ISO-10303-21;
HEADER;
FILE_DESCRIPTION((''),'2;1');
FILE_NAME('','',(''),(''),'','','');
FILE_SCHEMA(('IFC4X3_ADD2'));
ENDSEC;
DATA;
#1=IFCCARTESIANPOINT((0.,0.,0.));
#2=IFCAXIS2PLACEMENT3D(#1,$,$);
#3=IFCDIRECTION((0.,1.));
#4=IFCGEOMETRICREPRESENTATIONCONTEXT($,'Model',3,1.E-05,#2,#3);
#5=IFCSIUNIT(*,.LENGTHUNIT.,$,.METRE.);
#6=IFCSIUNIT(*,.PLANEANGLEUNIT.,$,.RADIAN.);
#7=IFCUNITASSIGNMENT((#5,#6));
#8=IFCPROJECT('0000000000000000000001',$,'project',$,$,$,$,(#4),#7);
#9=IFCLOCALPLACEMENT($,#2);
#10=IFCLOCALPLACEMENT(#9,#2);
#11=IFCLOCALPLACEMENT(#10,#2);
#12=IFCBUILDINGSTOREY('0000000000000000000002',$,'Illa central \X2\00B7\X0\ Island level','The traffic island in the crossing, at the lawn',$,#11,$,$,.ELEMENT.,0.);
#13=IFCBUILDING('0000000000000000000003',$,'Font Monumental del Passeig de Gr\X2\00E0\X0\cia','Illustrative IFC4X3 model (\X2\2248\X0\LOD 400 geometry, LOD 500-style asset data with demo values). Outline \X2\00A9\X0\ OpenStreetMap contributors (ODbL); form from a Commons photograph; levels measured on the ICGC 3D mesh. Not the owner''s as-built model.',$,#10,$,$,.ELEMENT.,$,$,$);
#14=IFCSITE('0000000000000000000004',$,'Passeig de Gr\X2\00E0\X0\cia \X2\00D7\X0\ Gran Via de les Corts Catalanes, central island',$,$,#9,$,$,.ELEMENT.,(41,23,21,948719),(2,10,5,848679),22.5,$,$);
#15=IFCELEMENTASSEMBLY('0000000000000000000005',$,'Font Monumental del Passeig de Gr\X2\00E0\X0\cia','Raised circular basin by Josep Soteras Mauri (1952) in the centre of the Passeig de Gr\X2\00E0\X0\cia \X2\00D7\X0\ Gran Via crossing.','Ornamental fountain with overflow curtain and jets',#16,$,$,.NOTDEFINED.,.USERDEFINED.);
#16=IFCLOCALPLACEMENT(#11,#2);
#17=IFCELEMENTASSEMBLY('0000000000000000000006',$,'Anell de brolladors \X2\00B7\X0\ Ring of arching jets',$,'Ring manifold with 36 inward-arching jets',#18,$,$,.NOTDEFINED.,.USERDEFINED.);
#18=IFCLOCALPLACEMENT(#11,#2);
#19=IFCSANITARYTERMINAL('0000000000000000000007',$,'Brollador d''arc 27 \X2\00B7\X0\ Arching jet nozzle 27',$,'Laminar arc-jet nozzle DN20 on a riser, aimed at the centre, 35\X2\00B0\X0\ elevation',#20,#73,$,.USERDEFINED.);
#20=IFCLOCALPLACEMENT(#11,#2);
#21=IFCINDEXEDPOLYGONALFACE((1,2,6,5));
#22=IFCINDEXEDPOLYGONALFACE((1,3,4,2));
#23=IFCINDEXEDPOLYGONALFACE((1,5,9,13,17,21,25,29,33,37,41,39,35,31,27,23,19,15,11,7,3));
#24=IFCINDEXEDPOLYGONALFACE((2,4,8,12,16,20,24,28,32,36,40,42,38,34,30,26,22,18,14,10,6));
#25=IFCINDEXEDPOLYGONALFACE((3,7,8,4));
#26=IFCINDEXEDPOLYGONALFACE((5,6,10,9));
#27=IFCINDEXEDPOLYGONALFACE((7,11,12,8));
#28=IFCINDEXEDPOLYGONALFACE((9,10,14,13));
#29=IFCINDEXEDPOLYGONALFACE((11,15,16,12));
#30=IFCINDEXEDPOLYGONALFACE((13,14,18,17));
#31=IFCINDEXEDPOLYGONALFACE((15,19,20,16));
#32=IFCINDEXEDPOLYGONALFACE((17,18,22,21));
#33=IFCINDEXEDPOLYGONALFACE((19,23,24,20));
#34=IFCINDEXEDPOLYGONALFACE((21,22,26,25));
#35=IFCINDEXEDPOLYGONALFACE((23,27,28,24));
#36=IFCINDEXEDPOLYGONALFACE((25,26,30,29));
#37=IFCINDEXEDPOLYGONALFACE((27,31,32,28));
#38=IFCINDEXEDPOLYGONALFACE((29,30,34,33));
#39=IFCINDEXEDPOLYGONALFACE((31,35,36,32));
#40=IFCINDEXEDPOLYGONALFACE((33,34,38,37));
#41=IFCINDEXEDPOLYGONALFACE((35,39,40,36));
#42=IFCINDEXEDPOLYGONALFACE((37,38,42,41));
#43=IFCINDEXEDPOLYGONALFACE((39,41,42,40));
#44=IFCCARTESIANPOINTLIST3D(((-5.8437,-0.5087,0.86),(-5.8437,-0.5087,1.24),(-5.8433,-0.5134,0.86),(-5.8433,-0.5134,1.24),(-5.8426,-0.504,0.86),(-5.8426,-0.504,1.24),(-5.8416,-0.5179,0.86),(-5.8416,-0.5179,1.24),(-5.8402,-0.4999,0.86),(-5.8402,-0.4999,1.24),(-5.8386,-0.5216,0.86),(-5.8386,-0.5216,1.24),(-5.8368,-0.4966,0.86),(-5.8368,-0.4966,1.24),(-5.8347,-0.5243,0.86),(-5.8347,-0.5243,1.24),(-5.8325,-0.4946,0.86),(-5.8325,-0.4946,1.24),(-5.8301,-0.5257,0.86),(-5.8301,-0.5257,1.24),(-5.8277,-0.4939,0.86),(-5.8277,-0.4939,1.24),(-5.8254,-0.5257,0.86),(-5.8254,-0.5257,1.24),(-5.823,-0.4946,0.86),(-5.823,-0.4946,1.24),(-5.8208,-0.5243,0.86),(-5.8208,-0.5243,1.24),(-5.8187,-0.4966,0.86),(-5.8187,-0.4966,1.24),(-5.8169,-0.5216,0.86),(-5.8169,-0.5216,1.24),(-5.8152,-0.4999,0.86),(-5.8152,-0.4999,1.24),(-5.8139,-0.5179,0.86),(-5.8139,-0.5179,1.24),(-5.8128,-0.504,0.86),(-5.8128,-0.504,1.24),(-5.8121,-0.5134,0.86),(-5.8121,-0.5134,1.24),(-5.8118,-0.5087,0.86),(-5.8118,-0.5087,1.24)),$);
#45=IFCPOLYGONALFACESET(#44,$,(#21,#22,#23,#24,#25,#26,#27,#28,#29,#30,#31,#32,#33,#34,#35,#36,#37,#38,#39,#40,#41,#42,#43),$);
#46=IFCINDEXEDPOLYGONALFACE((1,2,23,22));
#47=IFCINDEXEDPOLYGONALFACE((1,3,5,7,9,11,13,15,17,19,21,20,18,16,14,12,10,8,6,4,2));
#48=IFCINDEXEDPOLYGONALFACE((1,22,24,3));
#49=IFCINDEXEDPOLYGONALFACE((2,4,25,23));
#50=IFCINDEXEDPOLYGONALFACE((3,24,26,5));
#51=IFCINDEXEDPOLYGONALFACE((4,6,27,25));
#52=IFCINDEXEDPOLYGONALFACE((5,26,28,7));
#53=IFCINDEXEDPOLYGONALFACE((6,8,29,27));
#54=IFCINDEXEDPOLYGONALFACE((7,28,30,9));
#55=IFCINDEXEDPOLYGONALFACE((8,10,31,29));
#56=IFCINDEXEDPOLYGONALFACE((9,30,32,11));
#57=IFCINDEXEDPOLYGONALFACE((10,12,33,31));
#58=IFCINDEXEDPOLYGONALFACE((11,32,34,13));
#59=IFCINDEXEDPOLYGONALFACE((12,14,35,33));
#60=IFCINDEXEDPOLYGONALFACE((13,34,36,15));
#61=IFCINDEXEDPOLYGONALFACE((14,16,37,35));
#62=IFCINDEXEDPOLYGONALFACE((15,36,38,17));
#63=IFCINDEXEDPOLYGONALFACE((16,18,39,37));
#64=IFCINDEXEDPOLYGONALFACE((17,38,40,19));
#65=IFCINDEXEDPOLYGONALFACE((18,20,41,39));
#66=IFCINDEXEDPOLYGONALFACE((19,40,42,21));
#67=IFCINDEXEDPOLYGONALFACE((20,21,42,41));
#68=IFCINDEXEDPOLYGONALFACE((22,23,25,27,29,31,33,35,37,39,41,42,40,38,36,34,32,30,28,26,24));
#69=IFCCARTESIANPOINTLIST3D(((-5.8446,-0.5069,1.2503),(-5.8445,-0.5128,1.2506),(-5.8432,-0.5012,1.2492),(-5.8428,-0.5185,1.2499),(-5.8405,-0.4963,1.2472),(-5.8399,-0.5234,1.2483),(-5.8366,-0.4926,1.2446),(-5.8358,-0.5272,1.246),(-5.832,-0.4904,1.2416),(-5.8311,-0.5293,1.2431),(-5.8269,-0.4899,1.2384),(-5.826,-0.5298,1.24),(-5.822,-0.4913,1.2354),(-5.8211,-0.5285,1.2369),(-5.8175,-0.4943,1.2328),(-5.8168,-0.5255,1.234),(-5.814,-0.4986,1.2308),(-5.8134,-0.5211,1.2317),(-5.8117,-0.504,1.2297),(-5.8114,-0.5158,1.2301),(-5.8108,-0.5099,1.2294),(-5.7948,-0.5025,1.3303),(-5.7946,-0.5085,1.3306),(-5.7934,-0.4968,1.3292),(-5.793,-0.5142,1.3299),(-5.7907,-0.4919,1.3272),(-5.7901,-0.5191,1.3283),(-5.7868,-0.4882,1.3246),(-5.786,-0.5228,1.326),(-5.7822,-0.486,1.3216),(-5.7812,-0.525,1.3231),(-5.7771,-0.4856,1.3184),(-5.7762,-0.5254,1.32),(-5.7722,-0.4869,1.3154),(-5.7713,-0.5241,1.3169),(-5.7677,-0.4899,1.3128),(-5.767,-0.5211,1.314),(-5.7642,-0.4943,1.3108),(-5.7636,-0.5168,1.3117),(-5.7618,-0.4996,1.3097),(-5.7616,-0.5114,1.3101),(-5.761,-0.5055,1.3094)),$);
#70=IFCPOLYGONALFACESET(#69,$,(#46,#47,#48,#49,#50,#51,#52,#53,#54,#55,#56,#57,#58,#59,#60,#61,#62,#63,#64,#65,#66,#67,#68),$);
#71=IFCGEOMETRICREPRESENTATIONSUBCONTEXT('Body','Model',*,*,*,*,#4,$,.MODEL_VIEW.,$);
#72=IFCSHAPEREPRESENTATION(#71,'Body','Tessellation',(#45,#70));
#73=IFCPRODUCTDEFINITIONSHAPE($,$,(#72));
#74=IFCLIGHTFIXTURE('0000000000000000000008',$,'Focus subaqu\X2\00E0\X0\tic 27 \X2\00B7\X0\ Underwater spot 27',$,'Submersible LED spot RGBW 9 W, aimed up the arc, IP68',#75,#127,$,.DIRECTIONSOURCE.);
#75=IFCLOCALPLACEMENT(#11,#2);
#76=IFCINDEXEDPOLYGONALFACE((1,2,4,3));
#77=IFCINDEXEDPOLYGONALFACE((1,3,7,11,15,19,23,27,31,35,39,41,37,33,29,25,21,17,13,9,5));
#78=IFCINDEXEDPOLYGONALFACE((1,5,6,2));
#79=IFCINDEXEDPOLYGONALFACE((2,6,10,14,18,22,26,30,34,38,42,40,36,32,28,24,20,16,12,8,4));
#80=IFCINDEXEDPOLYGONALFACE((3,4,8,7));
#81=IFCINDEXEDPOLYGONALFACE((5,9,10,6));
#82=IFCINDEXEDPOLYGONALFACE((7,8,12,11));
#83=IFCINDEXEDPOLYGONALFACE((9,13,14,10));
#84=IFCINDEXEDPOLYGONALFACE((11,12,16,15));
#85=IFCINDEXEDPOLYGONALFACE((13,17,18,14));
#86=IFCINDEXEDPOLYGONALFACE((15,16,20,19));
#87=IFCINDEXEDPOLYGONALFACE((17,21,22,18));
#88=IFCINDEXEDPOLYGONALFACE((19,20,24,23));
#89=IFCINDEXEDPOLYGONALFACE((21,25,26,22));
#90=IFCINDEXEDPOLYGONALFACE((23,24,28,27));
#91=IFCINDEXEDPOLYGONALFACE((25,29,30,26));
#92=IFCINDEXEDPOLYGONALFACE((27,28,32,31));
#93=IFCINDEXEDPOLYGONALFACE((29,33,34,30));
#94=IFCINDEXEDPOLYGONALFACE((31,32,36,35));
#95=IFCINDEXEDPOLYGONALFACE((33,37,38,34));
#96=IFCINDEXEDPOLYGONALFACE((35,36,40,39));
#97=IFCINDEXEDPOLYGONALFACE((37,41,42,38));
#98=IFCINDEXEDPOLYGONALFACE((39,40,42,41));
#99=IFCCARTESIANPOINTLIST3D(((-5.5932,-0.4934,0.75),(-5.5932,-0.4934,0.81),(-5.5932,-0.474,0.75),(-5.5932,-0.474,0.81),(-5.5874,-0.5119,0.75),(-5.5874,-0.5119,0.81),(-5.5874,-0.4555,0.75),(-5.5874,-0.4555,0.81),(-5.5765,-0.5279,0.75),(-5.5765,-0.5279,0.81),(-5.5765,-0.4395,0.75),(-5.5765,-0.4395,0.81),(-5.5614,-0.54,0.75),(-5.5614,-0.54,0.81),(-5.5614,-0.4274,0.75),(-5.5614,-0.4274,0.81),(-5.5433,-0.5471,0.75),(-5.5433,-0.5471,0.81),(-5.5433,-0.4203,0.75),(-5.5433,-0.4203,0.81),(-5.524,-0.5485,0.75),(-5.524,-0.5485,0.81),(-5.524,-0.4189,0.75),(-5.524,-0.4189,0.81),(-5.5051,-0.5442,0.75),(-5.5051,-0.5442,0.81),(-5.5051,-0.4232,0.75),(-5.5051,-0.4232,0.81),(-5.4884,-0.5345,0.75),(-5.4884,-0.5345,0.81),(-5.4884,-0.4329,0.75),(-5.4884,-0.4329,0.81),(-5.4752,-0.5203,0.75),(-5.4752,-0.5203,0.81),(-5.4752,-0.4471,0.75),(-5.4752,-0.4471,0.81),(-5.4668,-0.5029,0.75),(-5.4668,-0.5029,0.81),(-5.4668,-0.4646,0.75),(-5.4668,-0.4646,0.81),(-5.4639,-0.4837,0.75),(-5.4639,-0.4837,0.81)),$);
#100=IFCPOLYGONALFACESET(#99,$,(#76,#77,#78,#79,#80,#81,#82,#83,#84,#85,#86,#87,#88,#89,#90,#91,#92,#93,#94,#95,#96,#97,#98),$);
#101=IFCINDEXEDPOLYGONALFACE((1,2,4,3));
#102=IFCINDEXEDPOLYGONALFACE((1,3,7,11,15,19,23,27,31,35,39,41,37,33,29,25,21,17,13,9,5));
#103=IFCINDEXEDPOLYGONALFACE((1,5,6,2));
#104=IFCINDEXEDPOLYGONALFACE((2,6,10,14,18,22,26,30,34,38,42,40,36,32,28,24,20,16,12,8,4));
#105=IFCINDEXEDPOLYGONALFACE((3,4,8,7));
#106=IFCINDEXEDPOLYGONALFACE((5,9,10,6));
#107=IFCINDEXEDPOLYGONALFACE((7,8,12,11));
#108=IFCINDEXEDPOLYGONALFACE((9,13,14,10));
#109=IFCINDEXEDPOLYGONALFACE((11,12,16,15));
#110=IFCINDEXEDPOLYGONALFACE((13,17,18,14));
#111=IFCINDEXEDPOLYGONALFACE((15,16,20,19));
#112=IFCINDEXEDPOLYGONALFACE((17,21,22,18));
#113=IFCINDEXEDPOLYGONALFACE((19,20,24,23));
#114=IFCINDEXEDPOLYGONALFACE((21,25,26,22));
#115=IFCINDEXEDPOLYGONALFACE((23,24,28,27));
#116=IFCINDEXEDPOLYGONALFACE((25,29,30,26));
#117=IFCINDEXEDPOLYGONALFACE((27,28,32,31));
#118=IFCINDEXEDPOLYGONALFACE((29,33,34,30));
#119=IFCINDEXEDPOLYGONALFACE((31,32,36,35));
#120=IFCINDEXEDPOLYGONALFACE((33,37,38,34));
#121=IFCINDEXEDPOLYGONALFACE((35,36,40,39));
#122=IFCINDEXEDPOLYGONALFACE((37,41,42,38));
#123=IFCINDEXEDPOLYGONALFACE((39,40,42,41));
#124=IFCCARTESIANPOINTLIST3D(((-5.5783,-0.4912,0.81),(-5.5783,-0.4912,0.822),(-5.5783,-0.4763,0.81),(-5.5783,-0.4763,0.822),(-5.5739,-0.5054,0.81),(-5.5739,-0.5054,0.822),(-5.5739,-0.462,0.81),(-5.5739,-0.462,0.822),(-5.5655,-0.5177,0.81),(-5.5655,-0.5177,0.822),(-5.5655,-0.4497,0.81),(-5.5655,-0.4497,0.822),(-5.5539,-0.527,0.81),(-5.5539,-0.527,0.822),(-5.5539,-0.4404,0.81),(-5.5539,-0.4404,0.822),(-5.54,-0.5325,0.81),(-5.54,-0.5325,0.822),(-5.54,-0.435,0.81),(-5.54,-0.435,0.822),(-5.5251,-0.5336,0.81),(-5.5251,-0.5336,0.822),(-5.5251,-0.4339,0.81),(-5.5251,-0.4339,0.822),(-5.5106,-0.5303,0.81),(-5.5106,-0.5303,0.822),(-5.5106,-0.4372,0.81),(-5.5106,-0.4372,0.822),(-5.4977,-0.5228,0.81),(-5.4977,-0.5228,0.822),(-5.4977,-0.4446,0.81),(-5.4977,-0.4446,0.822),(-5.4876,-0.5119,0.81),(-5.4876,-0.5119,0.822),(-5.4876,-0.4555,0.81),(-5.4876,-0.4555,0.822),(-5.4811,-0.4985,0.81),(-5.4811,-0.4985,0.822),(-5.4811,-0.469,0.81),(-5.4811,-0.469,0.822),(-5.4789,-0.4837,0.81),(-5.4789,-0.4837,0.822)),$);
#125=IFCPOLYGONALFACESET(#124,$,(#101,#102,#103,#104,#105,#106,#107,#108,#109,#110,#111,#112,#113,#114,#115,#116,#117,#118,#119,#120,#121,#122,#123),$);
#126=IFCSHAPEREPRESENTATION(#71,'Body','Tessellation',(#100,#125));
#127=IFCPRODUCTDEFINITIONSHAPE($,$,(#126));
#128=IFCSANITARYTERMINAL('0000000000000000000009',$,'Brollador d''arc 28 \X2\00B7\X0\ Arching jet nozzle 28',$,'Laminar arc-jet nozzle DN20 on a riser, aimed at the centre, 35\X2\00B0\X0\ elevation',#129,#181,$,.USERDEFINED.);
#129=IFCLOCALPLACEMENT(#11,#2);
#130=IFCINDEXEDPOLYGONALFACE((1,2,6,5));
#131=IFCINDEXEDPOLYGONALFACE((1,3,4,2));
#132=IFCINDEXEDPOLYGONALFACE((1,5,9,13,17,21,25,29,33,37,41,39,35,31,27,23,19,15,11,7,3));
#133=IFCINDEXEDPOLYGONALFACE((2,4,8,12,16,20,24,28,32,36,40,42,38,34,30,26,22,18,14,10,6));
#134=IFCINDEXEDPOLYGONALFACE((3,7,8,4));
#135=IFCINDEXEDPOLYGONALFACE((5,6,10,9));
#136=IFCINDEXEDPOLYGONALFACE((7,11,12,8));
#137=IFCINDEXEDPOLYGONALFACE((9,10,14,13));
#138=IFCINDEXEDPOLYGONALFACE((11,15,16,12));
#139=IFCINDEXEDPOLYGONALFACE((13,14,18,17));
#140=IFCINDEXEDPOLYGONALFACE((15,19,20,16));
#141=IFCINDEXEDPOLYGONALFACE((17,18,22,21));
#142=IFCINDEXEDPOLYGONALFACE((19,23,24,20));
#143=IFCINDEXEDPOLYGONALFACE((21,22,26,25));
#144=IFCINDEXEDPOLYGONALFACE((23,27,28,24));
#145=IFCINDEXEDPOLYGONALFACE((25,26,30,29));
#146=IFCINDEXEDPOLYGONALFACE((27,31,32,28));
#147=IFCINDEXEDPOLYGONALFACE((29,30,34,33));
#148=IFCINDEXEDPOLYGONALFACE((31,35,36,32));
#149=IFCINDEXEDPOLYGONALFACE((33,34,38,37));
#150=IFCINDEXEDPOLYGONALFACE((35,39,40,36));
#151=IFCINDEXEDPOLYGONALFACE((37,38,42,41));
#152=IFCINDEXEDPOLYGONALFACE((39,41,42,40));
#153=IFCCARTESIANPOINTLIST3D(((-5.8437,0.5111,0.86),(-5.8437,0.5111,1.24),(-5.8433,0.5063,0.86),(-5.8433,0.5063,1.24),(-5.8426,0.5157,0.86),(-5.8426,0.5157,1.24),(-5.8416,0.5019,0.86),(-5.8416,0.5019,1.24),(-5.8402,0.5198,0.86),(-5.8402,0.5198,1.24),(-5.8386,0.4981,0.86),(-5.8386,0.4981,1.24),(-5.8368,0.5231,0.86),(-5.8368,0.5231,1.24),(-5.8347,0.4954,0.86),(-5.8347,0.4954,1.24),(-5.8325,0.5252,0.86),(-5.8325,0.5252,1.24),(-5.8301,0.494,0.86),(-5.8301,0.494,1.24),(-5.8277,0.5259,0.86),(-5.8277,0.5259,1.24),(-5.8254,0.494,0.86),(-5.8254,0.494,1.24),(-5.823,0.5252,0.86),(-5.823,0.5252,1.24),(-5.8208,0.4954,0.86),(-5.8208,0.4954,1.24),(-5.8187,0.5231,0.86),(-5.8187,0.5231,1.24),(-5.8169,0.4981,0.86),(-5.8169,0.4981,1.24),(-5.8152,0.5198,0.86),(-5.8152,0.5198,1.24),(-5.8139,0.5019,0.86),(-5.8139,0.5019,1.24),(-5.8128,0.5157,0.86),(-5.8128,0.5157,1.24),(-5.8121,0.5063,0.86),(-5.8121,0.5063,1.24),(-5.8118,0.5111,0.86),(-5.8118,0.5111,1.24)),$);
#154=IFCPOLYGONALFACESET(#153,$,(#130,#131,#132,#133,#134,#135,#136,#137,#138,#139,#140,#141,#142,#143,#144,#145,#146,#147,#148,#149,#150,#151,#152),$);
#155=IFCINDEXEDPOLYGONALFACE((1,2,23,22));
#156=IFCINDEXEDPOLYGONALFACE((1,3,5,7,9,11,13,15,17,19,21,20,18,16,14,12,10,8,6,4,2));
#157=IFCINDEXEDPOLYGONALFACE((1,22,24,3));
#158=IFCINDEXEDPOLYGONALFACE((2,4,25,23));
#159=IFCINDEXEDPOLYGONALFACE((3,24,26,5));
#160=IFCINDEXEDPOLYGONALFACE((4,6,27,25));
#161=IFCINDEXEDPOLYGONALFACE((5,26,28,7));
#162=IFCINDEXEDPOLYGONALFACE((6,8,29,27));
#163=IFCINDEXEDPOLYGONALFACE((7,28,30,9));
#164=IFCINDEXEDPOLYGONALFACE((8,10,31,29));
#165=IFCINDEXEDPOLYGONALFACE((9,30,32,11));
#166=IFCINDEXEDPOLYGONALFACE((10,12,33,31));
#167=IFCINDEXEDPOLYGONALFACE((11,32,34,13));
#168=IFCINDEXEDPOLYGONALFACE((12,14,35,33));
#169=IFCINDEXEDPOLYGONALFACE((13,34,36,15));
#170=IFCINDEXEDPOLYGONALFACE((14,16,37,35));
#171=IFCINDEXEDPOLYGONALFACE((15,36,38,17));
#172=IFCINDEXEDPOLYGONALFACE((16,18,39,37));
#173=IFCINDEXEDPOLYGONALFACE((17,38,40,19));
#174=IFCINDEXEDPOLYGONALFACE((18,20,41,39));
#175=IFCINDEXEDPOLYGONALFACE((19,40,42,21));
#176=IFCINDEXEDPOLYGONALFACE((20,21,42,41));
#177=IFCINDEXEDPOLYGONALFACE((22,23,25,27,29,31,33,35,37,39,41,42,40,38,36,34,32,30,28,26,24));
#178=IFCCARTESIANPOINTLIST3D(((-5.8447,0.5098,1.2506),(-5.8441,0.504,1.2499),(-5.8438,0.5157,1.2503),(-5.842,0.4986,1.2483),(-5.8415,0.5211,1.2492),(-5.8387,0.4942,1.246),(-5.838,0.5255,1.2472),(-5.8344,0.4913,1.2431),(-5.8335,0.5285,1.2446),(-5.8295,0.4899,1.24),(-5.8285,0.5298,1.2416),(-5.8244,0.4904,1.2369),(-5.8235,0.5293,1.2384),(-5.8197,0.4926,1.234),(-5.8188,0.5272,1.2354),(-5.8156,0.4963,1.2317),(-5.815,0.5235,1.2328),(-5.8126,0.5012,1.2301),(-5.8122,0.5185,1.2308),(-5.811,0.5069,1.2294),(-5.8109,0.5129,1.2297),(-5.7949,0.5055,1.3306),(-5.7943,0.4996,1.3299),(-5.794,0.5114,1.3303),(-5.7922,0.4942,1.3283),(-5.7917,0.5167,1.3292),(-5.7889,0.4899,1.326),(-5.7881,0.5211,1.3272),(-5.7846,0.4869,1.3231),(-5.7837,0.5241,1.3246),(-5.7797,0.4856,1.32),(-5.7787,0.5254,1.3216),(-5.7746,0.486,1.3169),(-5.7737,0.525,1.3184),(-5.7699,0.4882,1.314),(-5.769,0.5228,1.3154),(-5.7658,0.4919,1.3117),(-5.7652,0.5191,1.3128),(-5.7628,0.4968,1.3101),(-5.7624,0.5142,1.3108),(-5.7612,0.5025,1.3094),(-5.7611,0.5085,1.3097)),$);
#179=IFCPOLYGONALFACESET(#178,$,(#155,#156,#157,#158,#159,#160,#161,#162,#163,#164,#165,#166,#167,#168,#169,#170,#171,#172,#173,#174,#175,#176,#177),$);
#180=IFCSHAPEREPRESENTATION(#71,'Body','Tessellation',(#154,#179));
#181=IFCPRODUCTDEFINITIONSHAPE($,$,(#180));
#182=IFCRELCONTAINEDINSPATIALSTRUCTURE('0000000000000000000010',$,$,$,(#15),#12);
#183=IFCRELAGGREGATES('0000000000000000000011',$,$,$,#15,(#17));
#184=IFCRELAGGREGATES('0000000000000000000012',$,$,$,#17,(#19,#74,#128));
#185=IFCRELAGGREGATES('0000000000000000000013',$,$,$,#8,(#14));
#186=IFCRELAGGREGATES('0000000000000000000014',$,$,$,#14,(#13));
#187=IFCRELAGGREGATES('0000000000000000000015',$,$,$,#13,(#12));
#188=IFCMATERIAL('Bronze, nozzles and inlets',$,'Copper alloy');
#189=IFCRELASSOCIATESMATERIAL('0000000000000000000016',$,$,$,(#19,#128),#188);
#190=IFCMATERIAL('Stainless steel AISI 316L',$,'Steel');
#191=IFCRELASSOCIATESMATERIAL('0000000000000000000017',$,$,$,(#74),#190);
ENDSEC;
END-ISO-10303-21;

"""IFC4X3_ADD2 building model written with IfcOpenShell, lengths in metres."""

from ifc_helpers import new_model, si_unit, direction, frame, origin, origin_2d_with_axis, place, context, subcontext, project, spatial, circle, extrude, material, element, aggregate, save


model = new_model("IFC4X3_ADD2")

# Units and contexts
model_context = context("Model", 3, precision=1e-05, world=origin(), true_north=direction((0.0, 1.0)))
body_context = subcontext(model_context, "Body", "Model", "MODEL_VIEW")
ifc_project = project(units=[si_unit("LENGTHUNIT", "METRE"), si_unit("PLANEANGLEUNIT", "RADIAN")], contexts=[model_context])

# Site, building, storey
site_placement = place(None, origin())
site = spatial("IfcSite", under=ifc_project, at=site_placement, Name="Passeig de Gràcia × Gran Via de les Corts Catalanes, central island", CompositionType="ELEMENT", RefLatitude=(41, 23, 21, 948719), RefLongitude=(2, 10, 5, 848679), RefElevation=22.5)
building_placement = place(site_placement, origin())
building = spatial("IfcBuilding", under=site, at=building_placement, Name="Font Monumental del Passeig de Gràcia", Description="Illustrative IFC4X3 model (≈LOD 400 geometry, LOD 500-style asset data with demo values). Outline © OpenStreetMap contributors (ODbL); form from a Commons photograph; levels measured on the ICGC 3D mesh. Not the owner's as-built model.", CompositionType="ELEMENT")
storey_placement = place(building_placement, origin())
storey = spatial("IfcBuildingStorey", under=building, at=storey_placement, Name="Illa central · Island level", Description="The traffic island in the crossing, at the lawn", CompositionType="ELEMENT", Elevation=0.0)

# Element assemblies, sanitary terminals, light fixture
assembly_1_placement = place(building_placement, origin())
assembly_1 = element("IfcElementAssembly", 1, at=assembly_1_placement, inside=storey, Name="Font Monumental del Passeig de Gràcia", Description="Raised circular basin by Josep Soteras Mauri (1952) in the centre of the Passeig de Gràcia × Gran Via crossing.", ObjectType="Ornamental fountain with overflow curtain and jets", AssemblyPlace="NOTDEFINED", PredefinedType="USERDEFINED")
assembly_2_placement = place(building_placement, origin())
assembly_2 = element("IfcElementAssembly", 2, at=assembly_2_placement, Name="Anell de brolladors · Ring of arching jets", ObjectType="Ring manifold with 36 inward-arching jets", AssemblyPlace="NOTDEFINED", PredefinedType="USERDEFINED")
aggregate(assembly_1, [assembly_2])
ifc_material_1 = material(Name="Stainless steel AISI 316L", Category="Steel")
ifc_material_2 = material(Name="Bronze, nozzles and inlets", Category="Copper alloy")
sanitary_terminal_1_placement = place(building_placement, origin())
sanitary_terminal_1 = element("IfcSanitaryTerminal", 3, at=sanitary_terminal_1_placement, material=ifc_material_2, Name="Brollador d'arc 27 · Arching jet nozzle 27", ObjectType="Laminar arc-jet nozzle DN20 on a riser, aimed at the centre, 35° elevation", PredefinedType="USERDEFINED", context=body_context, shape_type="SweptSolid", body=[
    extrude(circle(Radius=0.016, at=origin_2d_with_axis()), frame((-5.8277, -0.5099, 0.86), z_axis=(0.0, 0.0, 1.0), x_axis=(0.0, 1.0, 0.0)), (0.0, 0.0, 1.0), 0.38),
    extrude(circle(Radius=0.02, at=origin_2d_with_axis()), frame((-5.8277, -0.5099, 1.24), z_axis=(0.527982, 0.046192, 0.847998), x_axis=(0.087156, -0.996195, 0.0)), (0.0, 0.0, 1.0), 0.0943),
])
light_fixture_1_placement = place(building_placement, origin())
light_fixture_1 = element("IfcLightFixture", 4, at=light_fixture_1_placement, material=ifc_material_1, Name="Focus subaquàtic 27 · Underwater spot 27", ObjectType="Submersible LED spot RGBW 9 W, aimed up the arc, IP68", PredefinedType="DIRECTIONSOURCE", context=body_context, shape_type="SweptSolid", body=[
    extrude(circle(Radius=0.065, at=origin_2d_with_axis()), frame((-5.5289, -0.4837, 0.75)), (0.0, 0.0, 1.0), 0.06),
    extrude(circle(Radius=0.05, at=origin_2d_with_axis()), frame((-5.5289, -0.4837, 0.81)), (0.0, 0.0, 1.0), 0.012),
])
sanitary_terminal_2_placement = place(building_placement, origin())
sanitary_terminal_2 = element("IfcSanitaryTerminal", 5, at=sanitary_terminal_2_placement, material=ifc_material_2, Name="Brollador d'arc 28 · Arching jet nozzle 28", ObjectType="Laminar arc-jet nozzle DN20 on a riser, aimed at the centre, 35° elevation", PredefinedType="USERDEFINED", context=body_context, shape_type="SweptSolid", body=[
    extrude(circle(Radius=0.016, at=origin_2d_with_axis()), frame((-5.8277, 0.5099, 0.86), z_axis=(0.0, 0.0, 1.0), x_axis=(0.0, 1.0, 0.0)), (0.0, 0.0, 1.0), 0.38),
    extrude(circle(Radius=0.02, at=origin_2d_with_axis()), frame((-5.8277, 0.5099, 1.24), z_axis=(0.527982, -0.046192, 0.847998), x_axis=(-0.087156, -0.996195, 0.0)), (0.0, 0.0, 1.0), 0.0943),
])
aggregate(assembly_2, [sanitary_terminal_1, light_fixture_1, sanitary_terminal_2])

save(model, "model.ifc")
